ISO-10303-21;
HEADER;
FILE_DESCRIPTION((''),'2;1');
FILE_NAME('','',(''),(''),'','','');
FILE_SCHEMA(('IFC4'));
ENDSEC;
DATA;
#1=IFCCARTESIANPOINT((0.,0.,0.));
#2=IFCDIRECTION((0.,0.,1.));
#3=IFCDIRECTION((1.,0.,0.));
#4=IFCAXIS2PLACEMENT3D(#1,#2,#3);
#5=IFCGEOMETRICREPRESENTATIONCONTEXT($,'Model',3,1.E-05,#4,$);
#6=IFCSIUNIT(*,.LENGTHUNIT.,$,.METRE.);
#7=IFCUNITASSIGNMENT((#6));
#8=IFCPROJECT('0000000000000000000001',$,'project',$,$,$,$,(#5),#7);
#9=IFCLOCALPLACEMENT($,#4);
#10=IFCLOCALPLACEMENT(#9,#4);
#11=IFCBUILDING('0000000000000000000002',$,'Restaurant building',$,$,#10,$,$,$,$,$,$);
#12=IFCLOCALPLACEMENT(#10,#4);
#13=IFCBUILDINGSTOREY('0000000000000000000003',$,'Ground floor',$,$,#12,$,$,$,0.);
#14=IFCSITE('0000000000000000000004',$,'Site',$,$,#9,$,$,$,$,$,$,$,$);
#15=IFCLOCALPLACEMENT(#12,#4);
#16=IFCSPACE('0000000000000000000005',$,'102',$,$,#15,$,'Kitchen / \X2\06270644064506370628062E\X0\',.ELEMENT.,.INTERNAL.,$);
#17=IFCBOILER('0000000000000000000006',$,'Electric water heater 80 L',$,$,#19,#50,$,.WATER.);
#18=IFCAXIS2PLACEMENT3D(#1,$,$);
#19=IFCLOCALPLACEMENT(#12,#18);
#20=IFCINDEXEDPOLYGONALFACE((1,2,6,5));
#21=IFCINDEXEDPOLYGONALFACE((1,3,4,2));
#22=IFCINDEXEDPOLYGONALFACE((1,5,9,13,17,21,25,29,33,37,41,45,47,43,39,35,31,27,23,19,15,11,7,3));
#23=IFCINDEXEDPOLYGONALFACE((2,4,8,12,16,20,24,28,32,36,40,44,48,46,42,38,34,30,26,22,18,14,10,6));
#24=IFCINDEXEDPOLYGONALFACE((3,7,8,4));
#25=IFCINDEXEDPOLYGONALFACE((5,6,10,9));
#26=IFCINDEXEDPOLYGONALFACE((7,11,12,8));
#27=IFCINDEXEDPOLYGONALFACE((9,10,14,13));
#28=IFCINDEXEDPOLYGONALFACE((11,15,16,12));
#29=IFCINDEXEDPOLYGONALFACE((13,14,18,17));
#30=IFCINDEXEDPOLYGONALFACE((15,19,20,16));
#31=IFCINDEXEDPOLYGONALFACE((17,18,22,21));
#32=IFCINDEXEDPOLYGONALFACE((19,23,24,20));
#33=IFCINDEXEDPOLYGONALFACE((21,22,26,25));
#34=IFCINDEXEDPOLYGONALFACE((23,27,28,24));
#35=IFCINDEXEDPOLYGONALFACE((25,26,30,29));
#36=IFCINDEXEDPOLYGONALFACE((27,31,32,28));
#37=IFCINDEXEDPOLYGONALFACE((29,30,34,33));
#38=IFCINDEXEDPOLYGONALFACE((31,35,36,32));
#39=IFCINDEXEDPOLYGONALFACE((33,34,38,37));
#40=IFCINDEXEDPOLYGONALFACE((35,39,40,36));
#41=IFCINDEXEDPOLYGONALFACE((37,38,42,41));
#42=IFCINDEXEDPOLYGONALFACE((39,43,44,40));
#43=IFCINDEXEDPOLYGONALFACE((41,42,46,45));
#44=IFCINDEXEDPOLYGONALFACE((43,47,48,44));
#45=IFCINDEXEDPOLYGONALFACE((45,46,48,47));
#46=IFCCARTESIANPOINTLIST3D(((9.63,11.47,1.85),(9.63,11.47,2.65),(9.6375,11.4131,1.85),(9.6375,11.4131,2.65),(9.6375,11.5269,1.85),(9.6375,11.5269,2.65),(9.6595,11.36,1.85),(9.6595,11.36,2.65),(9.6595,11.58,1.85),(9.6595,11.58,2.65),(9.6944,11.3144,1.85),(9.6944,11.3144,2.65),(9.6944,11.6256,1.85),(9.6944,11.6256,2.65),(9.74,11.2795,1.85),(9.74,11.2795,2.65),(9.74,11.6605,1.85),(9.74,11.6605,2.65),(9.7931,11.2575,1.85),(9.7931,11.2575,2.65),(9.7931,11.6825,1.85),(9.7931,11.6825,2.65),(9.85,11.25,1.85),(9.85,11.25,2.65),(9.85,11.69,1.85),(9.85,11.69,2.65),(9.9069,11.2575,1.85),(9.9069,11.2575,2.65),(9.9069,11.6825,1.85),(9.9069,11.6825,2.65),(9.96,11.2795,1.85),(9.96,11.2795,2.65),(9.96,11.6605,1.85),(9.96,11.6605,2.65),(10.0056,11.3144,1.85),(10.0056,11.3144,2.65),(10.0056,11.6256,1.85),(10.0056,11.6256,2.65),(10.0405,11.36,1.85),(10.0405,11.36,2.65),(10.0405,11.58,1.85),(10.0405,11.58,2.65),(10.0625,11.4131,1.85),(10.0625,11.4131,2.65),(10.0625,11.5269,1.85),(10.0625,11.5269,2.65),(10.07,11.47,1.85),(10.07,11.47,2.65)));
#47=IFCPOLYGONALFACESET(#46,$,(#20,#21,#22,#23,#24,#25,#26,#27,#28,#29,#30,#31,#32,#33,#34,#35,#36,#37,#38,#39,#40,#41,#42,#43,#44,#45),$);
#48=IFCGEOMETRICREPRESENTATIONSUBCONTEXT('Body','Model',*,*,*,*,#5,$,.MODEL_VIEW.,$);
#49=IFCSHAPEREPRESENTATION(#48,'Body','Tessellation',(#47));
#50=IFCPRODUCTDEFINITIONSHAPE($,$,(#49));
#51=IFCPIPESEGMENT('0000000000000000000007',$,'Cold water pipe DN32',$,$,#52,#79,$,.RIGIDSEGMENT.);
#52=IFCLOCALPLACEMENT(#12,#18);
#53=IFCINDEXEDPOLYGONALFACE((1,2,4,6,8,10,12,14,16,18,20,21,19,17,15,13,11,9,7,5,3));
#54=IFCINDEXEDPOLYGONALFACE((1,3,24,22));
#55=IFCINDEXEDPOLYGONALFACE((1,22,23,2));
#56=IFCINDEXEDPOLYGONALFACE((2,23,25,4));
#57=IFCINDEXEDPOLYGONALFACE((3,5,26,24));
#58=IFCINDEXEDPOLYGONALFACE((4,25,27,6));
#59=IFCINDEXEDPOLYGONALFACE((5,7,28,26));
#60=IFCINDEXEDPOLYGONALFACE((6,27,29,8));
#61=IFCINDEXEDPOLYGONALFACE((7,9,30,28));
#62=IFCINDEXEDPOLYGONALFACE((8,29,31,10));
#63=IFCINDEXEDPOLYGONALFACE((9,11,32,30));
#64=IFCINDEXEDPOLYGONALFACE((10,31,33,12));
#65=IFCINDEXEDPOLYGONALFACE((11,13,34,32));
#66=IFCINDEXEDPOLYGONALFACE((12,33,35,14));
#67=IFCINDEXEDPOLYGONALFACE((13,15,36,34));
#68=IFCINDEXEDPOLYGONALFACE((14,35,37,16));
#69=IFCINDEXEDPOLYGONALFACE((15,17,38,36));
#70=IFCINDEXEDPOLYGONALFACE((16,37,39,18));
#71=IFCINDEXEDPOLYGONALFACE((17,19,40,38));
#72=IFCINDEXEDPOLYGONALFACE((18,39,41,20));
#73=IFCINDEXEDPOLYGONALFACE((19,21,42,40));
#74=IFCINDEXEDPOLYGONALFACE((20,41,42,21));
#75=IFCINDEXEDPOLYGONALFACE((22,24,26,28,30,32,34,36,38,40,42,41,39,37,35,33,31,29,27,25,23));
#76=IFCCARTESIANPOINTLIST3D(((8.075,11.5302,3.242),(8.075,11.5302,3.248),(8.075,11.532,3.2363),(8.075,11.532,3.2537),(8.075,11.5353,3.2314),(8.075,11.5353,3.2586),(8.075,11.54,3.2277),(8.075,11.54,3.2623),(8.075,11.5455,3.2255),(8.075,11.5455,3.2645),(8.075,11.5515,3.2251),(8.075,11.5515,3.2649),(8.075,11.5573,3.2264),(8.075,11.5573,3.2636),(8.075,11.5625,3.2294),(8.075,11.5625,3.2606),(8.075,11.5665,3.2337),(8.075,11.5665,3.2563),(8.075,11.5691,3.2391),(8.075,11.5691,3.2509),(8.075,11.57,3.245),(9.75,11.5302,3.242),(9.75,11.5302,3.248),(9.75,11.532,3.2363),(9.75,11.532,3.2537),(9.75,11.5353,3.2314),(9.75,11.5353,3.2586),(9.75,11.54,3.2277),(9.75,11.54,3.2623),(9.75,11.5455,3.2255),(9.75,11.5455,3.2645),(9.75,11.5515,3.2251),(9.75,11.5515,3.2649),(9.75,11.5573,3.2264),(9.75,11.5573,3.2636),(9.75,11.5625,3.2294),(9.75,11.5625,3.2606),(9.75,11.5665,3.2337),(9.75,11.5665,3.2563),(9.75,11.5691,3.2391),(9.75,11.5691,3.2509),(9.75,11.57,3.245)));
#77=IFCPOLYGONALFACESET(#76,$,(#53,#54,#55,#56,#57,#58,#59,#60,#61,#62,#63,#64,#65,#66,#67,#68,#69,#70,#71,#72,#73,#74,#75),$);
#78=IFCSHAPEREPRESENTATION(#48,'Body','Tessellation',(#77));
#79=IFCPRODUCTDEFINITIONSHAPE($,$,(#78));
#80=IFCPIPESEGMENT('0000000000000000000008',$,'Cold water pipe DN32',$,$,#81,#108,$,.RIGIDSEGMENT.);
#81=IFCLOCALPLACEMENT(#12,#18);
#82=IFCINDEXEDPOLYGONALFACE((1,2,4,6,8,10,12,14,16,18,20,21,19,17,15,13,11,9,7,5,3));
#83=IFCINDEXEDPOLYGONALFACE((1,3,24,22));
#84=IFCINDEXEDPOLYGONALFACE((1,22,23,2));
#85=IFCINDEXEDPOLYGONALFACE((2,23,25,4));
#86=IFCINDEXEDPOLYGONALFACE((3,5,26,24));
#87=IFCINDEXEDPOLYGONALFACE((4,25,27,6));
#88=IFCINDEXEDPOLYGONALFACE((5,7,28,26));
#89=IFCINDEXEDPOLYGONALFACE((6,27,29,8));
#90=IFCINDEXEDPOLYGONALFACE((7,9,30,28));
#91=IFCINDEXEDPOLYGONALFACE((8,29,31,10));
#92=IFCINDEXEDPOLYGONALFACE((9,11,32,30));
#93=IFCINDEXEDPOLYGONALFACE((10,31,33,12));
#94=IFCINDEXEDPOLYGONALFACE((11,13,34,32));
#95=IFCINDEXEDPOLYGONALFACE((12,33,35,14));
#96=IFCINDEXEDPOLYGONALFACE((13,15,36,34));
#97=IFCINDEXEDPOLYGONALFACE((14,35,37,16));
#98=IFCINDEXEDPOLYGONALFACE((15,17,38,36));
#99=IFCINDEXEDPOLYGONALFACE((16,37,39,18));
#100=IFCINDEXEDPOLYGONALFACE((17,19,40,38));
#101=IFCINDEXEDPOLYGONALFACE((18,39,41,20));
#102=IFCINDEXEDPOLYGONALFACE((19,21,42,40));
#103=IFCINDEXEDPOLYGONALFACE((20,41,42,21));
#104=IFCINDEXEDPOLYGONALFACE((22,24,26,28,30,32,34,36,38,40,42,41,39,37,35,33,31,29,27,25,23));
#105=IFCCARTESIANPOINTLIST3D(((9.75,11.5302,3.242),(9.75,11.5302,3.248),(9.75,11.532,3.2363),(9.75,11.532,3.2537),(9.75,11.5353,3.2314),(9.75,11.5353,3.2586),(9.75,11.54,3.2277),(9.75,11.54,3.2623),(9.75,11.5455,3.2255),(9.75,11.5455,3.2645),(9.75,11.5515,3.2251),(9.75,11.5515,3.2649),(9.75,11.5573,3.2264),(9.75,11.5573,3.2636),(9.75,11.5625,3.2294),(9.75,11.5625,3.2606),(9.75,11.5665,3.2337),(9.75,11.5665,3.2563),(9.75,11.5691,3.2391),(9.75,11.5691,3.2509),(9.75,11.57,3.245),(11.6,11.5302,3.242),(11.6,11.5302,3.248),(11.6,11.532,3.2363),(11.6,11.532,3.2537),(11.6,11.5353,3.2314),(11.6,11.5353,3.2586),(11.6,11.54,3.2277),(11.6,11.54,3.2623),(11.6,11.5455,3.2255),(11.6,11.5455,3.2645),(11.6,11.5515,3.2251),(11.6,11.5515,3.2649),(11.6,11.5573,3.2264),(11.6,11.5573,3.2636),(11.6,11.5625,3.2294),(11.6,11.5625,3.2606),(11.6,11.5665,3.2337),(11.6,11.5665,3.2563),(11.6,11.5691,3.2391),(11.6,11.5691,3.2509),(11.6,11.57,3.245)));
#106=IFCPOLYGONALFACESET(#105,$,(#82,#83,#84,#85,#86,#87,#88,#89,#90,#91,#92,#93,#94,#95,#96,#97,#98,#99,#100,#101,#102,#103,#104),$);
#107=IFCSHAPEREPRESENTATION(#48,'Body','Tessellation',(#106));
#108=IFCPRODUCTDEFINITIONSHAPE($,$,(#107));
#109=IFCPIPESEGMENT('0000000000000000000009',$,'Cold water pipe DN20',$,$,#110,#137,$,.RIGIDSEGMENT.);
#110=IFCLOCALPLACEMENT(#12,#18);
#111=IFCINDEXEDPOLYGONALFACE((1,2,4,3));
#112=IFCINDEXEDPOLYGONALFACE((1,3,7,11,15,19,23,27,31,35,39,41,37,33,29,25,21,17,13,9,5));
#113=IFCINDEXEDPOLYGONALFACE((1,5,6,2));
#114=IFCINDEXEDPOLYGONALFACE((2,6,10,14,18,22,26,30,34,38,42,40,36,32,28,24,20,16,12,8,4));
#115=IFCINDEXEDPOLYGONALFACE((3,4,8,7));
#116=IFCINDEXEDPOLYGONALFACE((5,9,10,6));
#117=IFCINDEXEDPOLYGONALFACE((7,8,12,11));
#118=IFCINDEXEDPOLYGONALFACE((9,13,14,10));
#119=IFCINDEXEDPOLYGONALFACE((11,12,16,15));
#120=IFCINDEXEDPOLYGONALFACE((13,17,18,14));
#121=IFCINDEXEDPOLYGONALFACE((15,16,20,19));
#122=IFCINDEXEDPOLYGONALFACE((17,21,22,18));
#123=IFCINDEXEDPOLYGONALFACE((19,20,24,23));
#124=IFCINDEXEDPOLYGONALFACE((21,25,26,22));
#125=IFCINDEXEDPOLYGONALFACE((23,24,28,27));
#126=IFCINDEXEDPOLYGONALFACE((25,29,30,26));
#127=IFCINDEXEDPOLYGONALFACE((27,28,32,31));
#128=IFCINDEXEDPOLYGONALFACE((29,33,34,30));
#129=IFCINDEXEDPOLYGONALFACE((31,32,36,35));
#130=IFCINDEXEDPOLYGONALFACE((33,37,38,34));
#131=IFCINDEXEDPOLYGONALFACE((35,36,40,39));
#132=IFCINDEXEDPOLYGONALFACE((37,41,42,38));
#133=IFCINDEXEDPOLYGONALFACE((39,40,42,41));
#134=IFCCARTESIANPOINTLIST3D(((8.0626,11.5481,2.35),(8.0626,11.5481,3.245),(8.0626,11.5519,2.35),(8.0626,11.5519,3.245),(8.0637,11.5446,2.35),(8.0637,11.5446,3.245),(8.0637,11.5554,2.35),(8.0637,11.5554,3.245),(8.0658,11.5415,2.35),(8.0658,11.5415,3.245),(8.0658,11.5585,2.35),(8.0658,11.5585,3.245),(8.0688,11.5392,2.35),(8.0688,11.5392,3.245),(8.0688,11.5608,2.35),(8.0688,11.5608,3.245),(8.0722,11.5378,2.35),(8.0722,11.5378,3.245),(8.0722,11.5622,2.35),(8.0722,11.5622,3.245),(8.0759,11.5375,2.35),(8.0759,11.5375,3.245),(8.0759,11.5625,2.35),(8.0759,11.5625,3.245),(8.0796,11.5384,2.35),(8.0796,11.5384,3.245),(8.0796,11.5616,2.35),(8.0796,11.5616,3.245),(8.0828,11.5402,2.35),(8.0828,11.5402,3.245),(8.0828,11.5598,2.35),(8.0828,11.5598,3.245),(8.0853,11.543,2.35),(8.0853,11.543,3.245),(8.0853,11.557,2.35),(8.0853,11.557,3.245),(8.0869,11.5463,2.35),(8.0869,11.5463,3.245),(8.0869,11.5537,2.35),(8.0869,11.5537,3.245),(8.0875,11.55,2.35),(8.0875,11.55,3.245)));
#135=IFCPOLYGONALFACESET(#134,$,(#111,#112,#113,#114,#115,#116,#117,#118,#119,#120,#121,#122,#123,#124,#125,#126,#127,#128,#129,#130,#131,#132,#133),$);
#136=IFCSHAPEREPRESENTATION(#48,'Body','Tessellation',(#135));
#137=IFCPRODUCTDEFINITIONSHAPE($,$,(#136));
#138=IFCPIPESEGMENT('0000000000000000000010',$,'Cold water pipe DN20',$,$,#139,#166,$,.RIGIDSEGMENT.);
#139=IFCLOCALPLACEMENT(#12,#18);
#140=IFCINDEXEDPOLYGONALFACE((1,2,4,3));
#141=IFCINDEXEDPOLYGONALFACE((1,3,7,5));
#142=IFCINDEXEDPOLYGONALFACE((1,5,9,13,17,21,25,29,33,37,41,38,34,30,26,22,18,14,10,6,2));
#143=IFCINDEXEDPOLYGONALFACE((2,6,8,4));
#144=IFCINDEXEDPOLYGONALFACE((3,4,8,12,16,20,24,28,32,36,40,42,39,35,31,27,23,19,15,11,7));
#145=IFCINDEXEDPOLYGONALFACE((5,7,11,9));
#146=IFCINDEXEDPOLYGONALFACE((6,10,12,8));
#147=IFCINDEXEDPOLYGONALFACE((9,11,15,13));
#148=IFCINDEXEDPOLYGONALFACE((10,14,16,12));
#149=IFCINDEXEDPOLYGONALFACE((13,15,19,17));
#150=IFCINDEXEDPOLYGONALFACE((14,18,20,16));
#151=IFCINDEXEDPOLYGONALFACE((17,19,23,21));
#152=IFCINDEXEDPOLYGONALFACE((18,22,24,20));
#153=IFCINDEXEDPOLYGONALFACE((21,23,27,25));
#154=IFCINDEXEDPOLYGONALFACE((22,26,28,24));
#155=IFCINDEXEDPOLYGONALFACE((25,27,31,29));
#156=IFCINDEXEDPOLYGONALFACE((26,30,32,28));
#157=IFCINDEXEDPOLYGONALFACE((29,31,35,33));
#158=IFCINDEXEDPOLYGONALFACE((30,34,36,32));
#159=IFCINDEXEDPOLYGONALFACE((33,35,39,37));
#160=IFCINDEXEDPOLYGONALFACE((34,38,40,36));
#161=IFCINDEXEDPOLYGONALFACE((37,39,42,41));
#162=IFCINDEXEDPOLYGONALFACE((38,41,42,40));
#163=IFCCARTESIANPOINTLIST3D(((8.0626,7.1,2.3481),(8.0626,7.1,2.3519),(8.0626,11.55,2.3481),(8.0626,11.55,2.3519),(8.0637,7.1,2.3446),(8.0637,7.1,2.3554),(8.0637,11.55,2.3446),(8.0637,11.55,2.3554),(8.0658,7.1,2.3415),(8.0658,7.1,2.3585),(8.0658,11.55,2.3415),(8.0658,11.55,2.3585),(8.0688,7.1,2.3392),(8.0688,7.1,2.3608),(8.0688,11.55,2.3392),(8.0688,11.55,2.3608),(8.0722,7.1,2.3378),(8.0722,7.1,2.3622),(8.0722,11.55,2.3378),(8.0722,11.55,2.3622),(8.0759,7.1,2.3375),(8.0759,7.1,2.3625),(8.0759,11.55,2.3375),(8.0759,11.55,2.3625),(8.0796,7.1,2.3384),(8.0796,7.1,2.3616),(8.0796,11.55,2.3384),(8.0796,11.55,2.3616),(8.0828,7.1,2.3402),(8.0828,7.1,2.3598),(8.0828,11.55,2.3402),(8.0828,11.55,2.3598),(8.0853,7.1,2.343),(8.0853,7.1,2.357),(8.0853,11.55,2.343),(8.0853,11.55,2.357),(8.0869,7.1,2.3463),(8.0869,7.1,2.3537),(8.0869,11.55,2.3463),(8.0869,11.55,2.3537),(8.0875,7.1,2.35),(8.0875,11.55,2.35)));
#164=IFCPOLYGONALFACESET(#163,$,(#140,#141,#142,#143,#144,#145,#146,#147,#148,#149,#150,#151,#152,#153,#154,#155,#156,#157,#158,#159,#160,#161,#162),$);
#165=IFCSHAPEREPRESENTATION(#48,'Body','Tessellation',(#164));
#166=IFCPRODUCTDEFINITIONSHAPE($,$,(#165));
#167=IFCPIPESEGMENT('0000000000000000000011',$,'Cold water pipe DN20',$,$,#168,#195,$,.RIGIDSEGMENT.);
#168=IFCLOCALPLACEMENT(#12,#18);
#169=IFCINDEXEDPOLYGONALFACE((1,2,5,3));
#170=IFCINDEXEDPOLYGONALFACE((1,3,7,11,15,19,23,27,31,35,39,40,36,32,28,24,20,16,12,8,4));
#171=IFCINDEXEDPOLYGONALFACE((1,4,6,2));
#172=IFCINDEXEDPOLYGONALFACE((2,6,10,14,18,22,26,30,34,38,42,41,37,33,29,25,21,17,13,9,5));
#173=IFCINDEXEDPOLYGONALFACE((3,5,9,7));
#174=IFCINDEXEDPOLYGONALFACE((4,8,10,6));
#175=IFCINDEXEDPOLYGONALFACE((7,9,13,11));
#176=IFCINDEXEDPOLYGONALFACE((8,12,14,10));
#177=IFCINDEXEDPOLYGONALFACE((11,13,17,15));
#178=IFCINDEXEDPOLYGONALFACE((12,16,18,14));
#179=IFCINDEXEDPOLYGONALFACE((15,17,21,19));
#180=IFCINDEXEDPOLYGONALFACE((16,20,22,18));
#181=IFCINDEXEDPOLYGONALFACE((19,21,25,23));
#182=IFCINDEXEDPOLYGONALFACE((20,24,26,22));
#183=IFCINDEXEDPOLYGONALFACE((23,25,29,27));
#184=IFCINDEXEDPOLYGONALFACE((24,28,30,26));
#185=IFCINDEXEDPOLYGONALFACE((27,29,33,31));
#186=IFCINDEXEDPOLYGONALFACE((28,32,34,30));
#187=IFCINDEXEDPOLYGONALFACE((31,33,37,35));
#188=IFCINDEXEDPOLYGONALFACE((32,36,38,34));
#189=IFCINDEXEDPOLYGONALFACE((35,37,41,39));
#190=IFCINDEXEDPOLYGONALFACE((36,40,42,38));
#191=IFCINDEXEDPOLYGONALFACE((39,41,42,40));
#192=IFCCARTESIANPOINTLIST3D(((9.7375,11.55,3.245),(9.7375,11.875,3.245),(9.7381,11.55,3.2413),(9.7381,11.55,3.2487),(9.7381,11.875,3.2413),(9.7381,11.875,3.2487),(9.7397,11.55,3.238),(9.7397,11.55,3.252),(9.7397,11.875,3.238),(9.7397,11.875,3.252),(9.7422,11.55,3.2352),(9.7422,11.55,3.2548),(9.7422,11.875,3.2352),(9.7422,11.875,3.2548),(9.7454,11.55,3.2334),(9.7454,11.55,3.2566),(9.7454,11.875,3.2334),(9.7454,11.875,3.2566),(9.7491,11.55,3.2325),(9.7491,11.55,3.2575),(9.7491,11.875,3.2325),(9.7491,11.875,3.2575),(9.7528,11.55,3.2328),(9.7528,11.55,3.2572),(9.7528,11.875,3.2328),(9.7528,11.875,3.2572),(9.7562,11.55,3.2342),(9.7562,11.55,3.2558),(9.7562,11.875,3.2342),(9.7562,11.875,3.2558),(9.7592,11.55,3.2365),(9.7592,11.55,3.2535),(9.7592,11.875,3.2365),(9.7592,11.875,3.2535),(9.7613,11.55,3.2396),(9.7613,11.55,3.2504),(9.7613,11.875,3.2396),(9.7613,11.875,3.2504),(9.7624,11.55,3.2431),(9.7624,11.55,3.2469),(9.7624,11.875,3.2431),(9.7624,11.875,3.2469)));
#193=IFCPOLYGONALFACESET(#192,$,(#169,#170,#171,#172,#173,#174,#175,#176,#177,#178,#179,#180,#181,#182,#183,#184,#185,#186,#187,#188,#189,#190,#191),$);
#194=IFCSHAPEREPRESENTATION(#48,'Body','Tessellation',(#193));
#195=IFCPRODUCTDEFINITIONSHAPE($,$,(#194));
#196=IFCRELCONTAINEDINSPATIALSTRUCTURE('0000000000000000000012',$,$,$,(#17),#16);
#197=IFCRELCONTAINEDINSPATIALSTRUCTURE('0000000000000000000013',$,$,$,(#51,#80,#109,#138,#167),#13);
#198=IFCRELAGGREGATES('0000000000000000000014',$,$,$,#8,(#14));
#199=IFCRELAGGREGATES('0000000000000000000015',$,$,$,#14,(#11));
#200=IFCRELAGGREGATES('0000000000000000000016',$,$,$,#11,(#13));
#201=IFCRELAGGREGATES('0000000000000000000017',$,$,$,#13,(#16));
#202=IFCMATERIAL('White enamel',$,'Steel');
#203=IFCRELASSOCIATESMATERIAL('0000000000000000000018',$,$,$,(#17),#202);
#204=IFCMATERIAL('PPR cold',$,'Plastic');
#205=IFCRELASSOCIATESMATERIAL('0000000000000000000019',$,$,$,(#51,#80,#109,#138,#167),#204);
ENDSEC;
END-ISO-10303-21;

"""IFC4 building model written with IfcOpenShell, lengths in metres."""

from ifc_helpers import new_model, si_unit, frame, origin_with_axes, origin_2d, place, context, subcontext, project, spatial, circle, extrude, material, element, save


model = new_model("IFC4")

# Units and contexts
model_context = context("Model", 3, precision=1e-05, world=origin_with_axes())
body_context = subcontext(model_context, "Body", "Model", "MODEL_VIEW")
ifc_project = project(units=[si_unit("LENGTHUNIT", "METRE")], contexts=[model_context])

# Site, building, storey, space
site_placement = place(None, origin_with_axes())
site = spatial("IfcSite", under=ifc_project, at=site_placement, Name="Site")
building_placement = place(site_placement, origin_with_axes())
building = spatial("IfcBuilding", under=site, at=building_placement, Name="Restaurant building")
storey_placement = place(building_placement, origin_with_axes())
storey = spatial("IfcBuildingStorey", under=building, at=storey_placement, Name="Ground floor", Elevation=0.0)
space_1_placement = place(storey_placement, origin_with_axes())
space_1 = spatial("IfcSpace", under=storey, at=space_1_placement, Name="102", LongName="Kitchen / المطبخ", CompositionType="ELEMENT", PredefinedType="INTERNAL")

# Boiler
ifc_material_1 = material(Name="White enamel", Category="Steel")
boiler_placement = place(storey_placement, frame((9.85, 11.47, 0.0)))
element("IfcBoiler", 1, at=boiler_placement, inside=space_1, material=ifc_material_1, Name="Electric water heater 80 L", PredefinedType="WATER", context=body_context, shape_type="SweptSolid", body=[
    extrude(circle(Radius=0.22, at=origin_2d()), frame((0.0, 0.0, 1.85)), (0.0, 0.0, 1.0), 0.8),
])

# Pipe segments
ifc_material_2 = material(Name="PPR cold", Category="Plastic")
pipe_segment_1_placement = place(storey_placement, frame((8.075, 11.55, 3.245)))
element("IfcPipeSegment", 2, at=pipe_segment_1_placement, inside=storey, material=ifc_material_2, Name="Cold water pipe DN32", PredefinedType="RIGIDSEGMENT", context=body_context, shape_type="SweptSolid", body=[
    extrude(circle(Radius=0.02, at=origin_2d()), frame((0.0, 0.0, 0.0), z_axis=(1.0, 0.0, 0.0), x_axis=(0.0, 1.0, 0.0)), (0.0, 0.0, 1.0), 1.675),
])
pipe_segment_2_placement = place(storey_placement, frame((9.75, 11.55, 3.245)))
element("IfcPipeSegment", 3, at=pipe_segment_2_placement, inside=storey, material=ifc_material_2, Name="Cold water pipe DN32", PredefinedType="RIGIDSEGMENT", context=body_context, shape_type="SweptSolid", body=[
    extrude(circle(Radius=0.02, at=origin_2d()), frame((0.0, 0.0, 0.0), z_axis=(1.0, 0.0, 0.0), x_axis=(0.0, 1.0, 0.0)), (0.0, 0.0, 1.0), 1.85),
])
pipe_segment_3_placement = place(storey_placement, frame((8.075, 11.55, 3.245)))
element("IfcPipeSegment", 4, at=pipe_segment_3_placement, inside=storey, material=ifc_material_2, Name="Cold water pipe DN20", PredefinedType="RIGIDSEGMENT", context=body_context, shape_type="SweptSolid", body=[
    extrude(circle(Radius=0.0125, at=origin_2d()), frame((0.0, 0.0, 0.0), z_axis=(0.0, 0.0, -1.0), x_axis=(1.0, 0.0, 0.0)), (0.0, 0.0, 1.0), 0.895),
])
pipe_segment_4_placement = place(storey_placement, frame((8.075, 11.55, 2.35)))
element("IfcPipeSegment", 5, at=pipe_segment_4_placement, inside=storey, material=ifc_material_2, Name="Cold water pipe DN20", PredefinedType="RIGIDSEGMENT", context=body_context, shape_type="SweptSolid", body=[
    extrude(circle(Radius=0.0125, at=origin_2d()), frame((0.0, 0.0, 0.0), z_axis=(0.0, -1.0, 0.0), x_axis=(1.0, 0.0, 0.0)), (0.0, 0.0, 1.0), 4.45),
])
pipe_segment_5_placement = place(storey_placement, frame((9.75, 11.55, 3.245)))
element("IfcPipeSegment", 6, at=pipe_segment_5_placement, inside=storey, material=ifc_material_2, Name="Cold water pipe DN20", PredefinedType="RIGIDSEGMENT", context=body_context, shape_type="SweptSolid", body=[
    extrude(circle(Radius=0.0125, at=origin_2d()), frame((0.0, 0.0, 0.0), z_axis=(0.0, 1.0, 0.0), x_axis=(-1.0, 0.0, 0.0)), (0.0, 0.0, 1.0), 0.325),
])

save(model, "model.ifc")
